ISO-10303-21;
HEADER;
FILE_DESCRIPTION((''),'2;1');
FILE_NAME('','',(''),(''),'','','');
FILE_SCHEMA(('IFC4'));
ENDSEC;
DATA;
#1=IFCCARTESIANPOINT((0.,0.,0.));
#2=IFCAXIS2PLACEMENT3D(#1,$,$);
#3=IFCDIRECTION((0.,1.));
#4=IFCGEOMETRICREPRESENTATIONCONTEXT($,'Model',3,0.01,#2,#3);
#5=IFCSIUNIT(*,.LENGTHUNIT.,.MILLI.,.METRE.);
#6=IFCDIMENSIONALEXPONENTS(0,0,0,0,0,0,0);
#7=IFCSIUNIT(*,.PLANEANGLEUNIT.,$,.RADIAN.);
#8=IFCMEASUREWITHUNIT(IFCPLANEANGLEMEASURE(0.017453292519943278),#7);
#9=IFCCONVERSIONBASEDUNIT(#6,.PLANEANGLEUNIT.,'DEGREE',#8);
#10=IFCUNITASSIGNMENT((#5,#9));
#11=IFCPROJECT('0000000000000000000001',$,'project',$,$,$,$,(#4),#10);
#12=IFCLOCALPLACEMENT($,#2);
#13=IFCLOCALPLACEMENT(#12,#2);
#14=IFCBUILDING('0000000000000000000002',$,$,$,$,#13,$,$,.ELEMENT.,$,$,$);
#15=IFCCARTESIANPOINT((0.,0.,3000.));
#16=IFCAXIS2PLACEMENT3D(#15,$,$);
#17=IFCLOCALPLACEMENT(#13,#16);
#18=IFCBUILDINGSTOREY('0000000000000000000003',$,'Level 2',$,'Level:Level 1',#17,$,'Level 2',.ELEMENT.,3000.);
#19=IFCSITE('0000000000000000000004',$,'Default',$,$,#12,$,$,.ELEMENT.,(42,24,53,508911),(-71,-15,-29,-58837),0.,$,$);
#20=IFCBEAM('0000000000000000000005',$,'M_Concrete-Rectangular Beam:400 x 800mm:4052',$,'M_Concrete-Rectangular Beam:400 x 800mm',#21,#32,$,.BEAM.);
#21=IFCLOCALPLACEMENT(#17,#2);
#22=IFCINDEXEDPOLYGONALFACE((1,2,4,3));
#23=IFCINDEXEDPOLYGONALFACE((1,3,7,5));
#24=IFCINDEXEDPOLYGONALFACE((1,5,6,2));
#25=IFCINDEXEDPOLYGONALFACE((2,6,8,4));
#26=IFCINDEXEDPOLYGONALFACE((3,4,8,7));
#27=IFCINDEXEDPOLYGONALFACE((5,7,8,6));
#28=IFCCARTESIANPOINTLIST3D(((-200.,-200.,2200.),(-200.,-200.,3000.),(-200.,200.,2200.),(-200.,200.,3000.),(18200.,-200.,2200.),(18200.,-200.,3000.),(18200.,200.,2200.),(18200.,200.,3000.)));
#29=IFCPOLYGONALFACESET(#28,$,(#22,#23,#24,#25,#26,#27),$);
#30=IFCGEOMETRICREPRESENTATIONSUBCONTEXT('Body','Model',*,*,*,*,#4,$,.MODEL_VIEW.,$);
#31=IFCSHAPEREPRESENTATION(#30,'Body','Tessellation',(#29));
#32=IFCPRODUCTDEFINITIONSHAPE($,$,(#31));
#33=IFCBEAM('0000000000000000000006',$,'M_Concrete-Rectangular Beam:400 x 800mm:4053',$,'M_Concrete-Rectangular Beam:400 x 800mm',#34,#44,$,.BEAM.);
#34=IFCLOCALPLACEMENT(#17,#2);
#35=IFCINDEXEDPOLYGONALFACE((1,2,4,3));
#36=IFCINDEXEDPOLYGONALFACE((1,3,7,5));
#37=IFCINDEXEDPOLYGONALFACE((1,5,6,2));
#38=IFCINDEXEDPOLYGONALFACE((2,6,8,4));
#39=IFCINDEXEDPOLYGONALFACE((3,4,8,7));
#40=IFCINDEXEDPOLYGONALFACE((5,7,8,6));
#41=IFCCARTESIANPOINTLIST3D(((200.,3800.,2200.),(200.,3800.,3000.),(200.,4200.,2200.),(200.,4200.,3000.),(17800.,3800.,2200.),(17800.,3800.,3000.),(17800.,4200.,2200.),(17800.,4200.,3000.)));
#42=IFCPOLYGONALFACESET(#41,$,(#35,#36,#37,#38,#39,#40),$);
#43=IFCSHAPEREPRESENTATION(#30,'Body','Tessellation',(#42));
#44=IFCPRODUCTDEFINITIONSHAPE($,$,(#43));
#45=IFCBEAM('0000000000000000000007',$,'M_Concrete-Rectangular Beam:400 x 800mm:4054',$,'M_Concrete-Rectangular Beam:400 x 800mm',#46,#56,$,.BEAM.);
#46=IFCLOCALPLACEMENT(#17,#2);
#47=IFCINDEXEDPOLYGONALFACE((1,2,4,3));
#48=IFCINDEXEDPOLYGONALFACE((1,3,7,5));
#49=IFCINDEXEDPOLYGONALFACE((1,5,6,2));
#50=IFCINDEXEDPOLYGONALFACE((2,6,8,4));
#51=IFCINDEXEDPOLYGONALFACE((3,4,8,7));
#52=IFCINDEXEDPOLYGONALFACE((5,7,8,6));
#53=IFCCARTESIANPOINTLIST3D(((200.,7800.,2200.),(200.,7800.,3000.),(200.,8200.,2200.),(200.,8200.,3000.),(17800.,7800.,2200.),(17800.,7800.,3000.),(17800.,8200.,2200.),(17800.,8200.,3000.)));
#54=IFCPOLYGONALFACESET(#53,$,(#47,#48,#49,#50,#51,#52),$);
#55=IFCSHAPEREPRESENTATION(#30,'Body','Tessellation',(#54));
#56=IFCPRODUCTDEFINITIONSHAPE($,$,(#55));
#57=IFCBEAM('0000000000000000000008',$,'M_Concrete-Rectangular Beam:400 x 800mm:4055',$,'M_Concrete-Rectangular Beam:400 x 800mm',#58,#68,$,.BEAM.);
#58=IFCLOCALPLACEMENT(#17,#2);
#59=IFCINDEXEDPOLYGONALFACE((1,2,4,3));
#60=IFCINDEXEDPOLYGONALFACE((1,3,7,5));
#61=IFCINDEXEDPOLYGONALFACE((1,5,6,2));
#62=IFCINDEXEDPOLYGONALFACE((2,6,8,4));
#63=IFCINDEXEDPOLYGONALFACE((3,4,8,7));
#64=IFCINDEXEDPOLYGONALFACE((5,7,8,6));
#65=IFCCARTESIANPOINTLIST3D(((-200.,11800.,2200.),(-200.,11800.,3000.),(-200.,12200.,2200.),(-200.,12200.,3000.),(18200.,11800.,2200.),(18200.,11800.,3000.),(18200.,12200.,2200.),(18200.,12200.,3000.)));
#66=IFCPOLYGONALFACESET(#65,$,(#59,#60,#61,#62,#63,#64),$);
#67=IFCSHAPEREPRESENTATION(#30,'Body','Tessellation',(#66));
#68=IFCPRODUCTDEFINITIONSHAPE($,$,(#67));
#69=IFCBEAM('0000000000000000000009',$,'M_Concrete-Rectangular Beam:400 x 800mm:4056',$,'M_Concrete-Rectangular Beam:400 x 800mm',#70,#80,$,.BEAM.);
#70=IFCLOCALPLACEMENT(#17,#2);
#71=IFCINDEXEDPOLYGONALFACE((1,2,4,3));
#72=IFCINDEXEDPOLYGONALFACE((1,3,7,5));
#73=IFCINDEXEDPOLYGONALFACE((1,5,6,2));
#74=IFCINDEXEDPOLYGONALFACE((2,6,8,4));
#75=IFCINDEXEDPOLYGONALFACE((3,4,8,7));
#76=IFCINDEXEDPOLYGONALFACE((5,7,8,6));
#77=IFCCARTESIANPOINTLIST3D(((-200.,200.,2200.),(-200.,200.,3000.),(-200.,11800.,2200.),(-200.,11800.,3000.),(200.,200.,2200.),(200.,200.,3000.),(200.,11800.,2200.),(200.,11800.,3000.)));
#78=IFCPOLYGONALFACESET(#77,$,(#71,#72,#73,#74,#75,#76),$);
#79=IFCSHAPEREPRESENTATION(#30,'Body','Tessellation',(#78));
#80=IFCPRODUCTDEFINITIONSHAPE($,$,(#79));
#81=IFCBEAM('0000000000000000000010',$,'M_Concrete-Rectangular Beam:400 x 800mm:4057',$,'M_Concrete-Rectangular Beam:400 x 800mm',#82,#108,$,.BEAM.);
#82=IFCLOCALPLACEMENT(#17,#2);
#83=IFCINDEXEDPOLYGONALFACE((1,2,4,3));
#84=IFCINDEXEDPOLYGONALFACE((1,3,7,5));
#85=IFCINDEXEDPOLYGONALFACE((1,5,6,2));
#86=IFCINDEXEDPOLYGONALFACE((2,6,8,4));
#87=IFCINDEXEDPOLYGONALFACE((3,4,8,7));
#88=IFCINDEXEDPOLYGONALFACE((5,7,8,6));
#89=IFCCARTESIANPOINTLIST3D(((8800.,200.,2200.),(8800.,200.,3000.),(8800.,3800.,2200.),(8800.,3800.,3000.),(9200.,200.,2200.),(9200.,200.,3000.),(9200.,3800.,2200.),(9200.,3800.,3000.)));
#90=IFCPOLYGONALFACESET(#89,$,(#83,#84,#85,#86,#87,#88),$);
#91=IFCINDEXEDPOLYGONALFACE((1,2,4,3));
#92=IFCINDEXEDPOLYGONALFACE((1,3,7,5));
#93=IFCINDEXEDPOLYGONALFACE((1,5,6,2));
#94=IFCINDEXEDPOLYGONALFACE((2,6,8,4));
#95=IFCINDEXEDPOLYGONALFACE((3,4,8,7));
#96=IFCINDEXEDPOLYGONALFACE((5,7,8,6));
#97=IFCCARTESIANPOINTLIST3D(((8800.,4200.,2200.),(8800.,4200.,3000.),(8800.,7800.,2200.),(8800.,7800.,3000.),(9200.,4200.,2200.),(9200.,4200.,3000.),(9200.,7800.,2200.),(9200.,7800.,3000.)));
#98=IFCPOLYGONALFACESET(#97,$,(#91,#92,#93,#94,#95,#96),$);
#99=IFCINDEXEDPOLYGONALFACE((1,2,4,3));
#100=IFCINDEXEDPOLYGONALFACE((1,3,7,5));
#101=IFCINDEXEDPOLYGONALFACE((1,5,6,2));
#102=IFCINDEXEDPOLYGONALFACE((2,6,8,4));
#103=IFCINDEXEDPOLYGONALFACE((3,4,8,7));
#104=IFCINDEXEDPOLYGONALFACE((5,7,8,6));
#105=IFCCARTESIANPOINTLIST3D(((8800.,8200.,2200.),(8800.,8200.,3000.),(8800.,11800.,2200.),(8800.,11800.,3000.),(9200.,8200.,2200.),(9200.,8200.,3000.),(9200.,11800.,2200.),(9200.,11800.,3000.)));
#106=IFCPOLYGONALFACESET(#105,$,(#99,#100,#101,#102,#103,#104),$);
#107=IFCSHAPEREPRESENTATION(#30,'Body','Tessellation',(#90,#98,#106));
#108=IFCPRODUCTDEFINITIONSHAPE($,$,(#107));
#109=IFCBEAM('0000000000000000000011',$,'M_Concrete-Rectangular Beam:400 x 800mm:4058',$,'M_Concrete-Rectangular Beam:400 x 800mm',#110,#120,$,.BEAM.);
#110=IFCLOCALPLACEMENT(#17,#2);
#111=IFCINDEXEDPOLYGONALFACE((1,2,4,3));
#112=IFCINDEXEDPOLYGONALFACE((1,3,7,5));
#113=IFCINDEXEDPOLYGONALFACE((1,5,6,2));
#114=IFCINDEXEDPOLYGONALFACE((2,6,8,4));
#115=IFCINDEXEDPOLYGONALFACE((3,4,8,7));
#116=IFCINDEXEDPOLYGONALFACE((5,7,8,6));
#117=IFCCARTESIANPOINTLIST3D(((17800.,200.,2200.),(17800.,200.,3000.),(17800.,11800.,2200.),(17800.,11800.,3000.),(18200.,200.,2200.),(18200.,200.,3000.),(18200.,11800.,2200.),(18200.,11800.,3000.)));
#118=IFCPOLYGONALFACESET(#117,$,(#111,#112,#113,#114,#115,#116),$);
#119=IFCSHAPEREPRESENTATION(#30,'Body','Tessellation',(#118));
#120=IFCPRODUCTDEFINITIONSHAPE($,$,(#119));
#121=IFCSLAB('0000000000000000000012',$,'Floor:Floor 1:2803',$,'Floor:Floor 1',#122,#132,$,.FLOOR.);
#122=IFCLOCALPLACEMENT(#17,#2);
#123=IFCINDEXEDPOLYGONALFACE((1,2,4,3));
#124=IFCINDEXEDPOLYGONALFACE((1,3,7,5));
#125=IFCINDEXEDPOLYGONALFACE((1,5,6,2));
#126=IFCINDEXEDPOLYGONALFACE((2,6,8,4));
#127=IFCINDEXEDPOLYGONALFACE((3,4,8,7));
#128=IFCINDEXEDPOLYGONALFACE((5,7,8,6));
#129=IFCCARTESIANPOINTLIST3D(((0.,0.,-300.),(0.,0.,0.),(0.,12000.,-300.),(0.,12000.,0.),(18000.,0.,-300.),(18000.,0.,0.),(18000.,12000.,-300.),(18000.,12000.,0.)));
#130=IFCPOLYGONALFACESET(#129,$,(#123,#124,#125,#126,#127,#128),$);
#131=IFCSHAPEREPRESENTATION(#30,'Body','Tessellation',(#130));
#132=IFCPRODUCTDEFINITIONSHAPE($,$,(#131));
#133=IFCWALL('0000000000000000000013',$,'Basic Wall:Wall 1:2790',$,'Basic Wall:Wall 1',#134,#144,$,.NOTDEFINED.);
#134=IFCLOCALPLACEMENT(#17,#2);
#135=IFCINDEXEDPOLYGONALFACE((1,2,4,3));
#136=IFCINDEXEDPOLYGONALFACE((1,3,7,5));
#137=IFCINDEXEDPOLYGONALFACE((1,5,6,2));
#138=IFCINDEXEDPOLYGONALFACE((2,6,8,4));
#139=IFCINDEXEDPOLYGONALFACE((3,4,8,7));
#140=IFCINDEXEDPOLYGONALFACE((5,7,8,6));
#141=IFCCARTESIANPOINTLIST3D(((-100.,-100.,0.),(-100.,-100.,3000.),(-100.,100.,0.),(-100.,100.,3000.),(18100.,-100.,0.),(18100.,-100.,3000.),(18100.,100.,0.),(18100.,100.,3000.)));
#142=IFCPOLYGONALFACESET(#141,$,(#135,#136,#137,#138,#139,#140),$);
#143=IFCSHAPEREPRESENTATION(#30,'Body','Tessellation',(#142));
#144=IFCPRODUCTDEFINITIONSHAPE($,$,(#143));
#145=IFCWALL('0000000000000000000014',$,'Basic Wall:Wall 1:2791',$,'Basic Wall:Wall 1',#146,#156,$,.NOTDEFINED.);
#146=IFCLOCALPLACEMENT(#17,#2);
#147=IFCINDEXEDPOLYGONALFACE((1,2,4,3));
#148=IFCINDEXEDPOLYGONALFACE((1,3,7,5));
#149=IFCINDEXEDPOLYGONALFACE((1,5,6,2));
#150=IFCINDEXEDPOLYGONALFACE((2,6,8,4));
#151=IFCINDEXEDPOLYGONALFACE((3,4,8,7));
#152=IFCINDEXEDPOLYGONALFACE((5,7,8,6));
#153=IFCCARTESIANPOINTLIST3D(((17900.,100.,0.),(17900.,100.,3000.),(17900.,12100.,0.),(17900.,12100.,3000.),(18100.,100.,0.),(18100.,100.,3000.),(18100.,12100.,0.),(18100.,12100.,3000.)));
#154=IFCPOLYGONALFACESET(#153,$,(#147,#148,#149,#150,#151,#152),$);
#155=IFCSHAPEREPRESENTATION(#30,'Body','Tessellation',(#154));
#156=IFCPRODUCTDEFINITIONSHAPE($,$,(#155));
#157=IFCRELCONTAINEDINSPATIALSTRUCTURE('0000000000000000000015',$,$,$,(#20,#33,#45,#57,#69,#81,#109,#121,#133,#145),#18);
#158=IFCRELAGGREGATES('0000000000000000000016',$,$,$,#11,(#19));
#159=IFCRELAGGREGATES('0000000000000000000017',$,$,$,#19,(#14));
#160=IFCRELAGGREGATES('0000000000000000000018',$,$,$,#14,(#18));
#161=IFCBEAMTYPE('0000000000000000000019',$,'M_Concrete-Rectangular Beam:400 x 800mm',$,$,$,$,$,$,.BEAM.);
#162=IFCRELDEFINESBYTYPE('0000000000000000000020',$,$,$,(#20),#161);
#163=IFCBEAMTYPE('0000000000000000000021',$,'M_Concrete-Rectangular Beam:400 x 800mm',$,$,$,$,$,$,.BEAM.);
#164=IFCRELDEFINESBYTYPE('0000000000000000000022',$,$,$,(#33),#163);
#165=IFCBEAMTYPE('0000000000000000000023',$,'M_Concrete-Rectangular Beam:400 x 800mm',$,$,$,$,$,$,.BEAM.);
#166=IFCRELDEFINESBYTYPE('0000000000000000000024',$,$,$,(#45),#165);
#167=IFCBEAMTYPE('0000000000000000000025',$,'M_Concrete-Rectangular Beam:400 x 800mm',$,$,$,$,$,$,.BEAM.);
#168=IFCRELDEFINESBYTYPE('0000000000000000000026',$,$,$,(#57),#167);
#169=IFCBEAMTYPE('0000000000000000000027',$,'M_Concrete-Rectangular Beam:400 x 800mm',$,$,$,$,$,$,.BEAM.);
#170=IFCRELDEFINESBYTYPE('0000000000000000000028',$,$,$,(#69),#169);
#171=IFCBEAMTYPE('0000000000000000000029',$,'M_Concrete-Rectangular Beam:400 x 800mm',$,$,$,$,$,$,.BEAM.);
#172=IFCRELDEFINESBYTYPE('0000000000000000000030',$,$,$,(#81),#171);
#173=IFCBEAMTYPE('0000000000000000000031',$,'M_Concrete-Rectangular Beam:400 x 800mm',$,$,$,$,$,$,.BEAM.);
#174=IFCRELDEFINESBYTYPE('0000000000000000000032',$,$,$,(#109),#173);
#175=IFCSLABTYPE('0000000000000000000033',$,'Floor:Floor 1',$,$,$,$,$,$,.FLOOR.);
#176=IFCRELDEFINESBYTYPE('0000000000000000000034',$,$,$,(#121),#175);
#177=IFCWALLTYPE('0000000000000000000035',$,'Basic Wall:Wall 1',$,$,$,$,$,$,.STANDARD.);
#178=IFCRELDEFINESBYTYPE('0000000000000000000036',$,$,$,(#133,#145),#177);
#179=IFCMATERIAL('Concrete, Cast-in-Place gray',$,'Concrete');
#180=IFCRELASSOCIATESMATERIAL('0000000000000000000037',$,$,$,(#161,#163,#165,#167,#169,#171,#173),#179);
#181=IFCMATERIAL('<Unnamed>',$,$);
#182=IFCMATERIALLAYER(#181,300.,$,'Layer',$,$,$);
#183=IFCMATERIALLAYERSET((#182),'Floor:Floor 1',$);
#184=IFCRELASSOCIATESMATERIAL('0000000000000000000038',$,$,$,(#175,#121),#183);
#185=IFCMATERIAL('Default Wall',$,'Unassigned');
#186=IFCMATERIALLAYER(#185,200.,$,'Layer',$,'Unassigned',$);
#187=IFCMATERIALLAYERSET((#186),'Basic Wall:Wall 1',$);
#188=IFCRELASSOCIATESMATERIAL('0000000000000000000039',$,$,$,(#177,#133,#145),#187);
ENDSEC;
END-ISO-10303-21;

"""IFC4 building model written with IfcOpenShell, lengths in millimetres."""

from ifc_helpers import new_model, entity, si_unit, converted_unit, direction, frame, frame_2d, origin, origin_2d_with_axis, place, context, subcontext, project, spatial, rectangle, extrude, source, transform, mapped, material, layer, layer_set, layer_usage, material_profile, profile_set, type_object, type_shapes, element, save


model = new_model("IFC4")

# Units and contexts
model_context = context("Model", 3, precision=0.01, world=origin(), true_north=direction((0.0, 1.0)))
body_context = subcontext(model_context, "Body", "Model", "MODEL_VIEW")
ifc_project = project(units=[si_unit("LENGTHUNIT", "METRE", prefix="MILLI"), converted_unit("PLANEANGLEUNIT", "DEGREE", entity("IfcPlaneAngleMeasure", 0.017453292519943278), si_unit("PLANEANGLEUNIT", "RADIAN"), dimensions=[0, 0, 0, 0, 0, 0, 0])], contexts=[model_context])

# Site, building, storey
site_placement = place(None, origin())
site = spatial("IfcSite", under=ifc_project, at=site_placement, Name="Default", CompositionType="ELEMENT", RefLatitude=(42, 24, 53, 508911), RefLongitude=(-71, -15, -29, -58837), RefElevation=0.0)
building_placement = place(site_placement, origin())
building = spatial("IfcBuilding", under=site, at=building_placement, CompositionType="ELEMENT")
storey_placement = place(building_placement, frame((0.0, 0.0, 3000.0)))
storey = spatial("IfcBuildingStorey", under=building, at=storey_placement, Name="Level 2", ObjectType="Level:Level 1", LongName="Level 2", CompositionType="ELEMENT", Elevation=3000.0)

# Beams
ifc_material_1 = material(Name="Concrete, Cast-in-Place gray", Category="Concrete")
ifc_material_profile = material_profile(ifc_material_1, rectangle(XDim=800.0, YDim=400.0, at=origin_2d_with_axis()), Name="400 x 800mm")
ifc_profile_set = profile_set([ifc_material_profile], Name="400 x 800mm")
beam_type_1 = type_object("IfcBeamType", Name="M_Concrete-Rectangular Beam:400 x 800mm", PredefinedType="BEAM", material=ifc_profile_set)
shared_shape_1 = source(origin(), body_context, "Body", "SweptSolid", [
    extrude(rectangle(XDim=800.0, YDim=400.0, at=origin_2d_with_axis()), frame((-200.0, 0.0, 5600.0), z_axis=(1.0, 0.0, 0.0), x_axis=(0.0, 0.0, -1.0)), (0.0, 0.0, 1.0), 18400.0),
])
type_shapes(beam_type_1, [shared_shape_1])
beam_1_placement = place(storey_placement, frame((0.0, 0.0, -3000.0)))
element("IfcBeam", 1, at=beam_1_placement, inside=storey, type_object=beam_type_1, Name="M_Concrete-Rectangular Beam:400 x 800mm:4052", ObjectType="M_Concrete-Rectangular Beam:400 x 800mm", PredefinedType="BEAM", context=body_context, shape_type="MappedRepresentation", body=[
    mapped(shared_shape_1, transform((0.0, 0.0, 0.0), scale=1.0)),
])
beam_type_2 = type_object("IfcBeamType", Name="M_Concrete-Rectangular Beam:400 x 800mm", PredefinedType="BEAM", material=ifc_profile_set)
shared_shape_2 = source(origin(), body_context, "Body", "SweptSolid", [
    extrude(rectangle(XDim=800.0, YDim=400.0, at=origin_2d_with_axis()), frame((200.0, 4000.0, 5600.0), z_axis=(1.0, 0.0, 0.0), x_axis=(0.0, 0.0, -1.0)), (0.0, 0.0, 1.0), 17600.0),
])
type_shapes(beam_type_2, [shared_shape_2])
beam_2_placement = place(storey_placement, frame((0.0, 0.0, -3000.0)))
element("IfcBeam", 2, at=beam_2_placement, inside=storey, type_object=beam_type_2, Name="M_Concrete-Rectangular Beam:400 x 800mm:4053", ObjectType="M_Concrete-Rectangular Beam:400 x 800mm", PredefinedType="BEAM", context=body_context, shape_type="MappedRepresentation", body=[
    mapped(shared_shape_2, transform((0.0, 0.0, 0.0), scale=1.0)),
])
beam_type_3 = type_object("IfcBeamType", Name="M_Concrete-Rectangular Beam:400 x 800mm", PredefinedType="BEAM", material=ifc_profile_set)
shared_shape_3 = source(origin(), body_context, "Body", "SweptSolid", [
    extrude(rectangle(XDim=800.0, YDim=400.0, at=frame_2d((0.0, 0.0), x_axis=(1.0, 0.0))), frame((200.0, 8000.0, 5600.0), z_axis=(1.0, 0.0, 0.0), x_axis=(0.0, 0.0, -1.0)), (0.0, 0.0, 1.0), 17600.0),
])
type_shapes(beam_type_3, [shared_shape_3])
beam_3_placement = place(storey_placement, frame((0.0, 0.0, -3000.0)))
element("IfcBeam", 3, at=beam_3_placement, inside=storey, type_object=beam_type_3, Name="M_Concrete-Rectangular Beam:400 x 800mm:4054", ObjectType="M_Concrete-Rectangular Beam:400 x 800mm", PredefinedType="BEAM", context=body_context, shape_type="MappedRepresentation", body=[
    mapped(shared_shape_3, transform((0.0, 0.0, 0.0), scale=1.0)),
])
beam_type_4 = type_object("IfcBeamType", Name="M_Concrete-Rectangular Beam:400 x 800mm", PredefinedType="BEAM", material=ifc_profile_set)
shared_shape_4 = source(origin(), body_context, "Body", "SweptSolid", [
    extrude(rectangle(XDim=800.0, YDim=400.0, at=frame_2d((0.0, 0.0), x_axis=(1.0, 0.0))), frame((-200.0, 12000.0, 5600.0), z_axis=(1.0, 0.0, 0.0), x_axis=(0.0, 0.0, -1.0)), (0.0, 0.0, 1.0), 18400.0),
])
type_shapes(beam_type_4, [shared_shape_4])
beam_4_placement = place(storey_placement, frame((0.0, 0.0, -3000.0)))
element("IfcBeam", 4, at=beam_4_placement, inside=storey, type_object=beam_type_4, Name="M_Concrete-Rectangular Beam:400 x 800mm:4055", ObjectType="M_Concrete-Rectangular Beam:400 x 800mm", PredefinedType="BEAM", context=body_context, shape_type="MappedRepresentation", body=[
    mapped(shared_shape_4, transform((0.0, 0.0, 0.0), scale=1.0)),
])
beam_type_5 = type_object("IfcBeamType", Name="M_Concrete-Rectangular Beam:400 x 800mm", PredefinedType="BEAM", material=ifc_profile_set)
shared_shape_5 = source(origin(), body_context, "Body", "SweptSolid", [
    extrude(rectangle(XDim=800.0, YDim=400.0, at=frame_2d((0.0, 0.0), x_axis=(0.0, 1.0))), frame((0.0, 200.0, 5600.0), z_axis=(0.0, 1.0, 0.0), x_axis=(-1.0, 0.0, 0.0)), (0.0, 0.0, 1.0), 11600.0),
])
type_shapes(beam_type_5, [shared_shape_5])
beam_5_placement = place(storey_placement, frame((0.0, 0.0, -3000.0)))
element("IfcBeam", 5, at=beam_5_placement, inside=storey, type_object=beam_type_5, Name="M_Concrete-Rectangular Beam:400 x 800mm:4056", ObjectType="M_Concrete-Rectangular Beam:400 x 800mm", PredefinedType="BEAM", context=body_context, shape_type="MappedRepresentation", body=[
    mapped(shared_shape_5, transform((0.0, 0.0, 0.0), scale=1.0)),
])
beam_type_6 = type_object("IfcBeamType", Name="M_Concrete-Rectangular Beam:400 x 800mm", PredefinedType="BEAM", material=ifc_profile_set)
shared_shape_6 = source(origin(), body_context, "Body", "SweptSolid", [
    extrude(rectangle(XDim=800.0, YDim=400.0, at=frame_2d((0.0, 0.0), x_axis=(0.0, 1.0))), frame((9000.0, 200.0, 5600.0), z_axis=(0.0, 1.0, 0.0), x_axis=(-1.0, 0.0, 0.0)), (0.0, 0.0, 1.0), 3600.0),
    extrude(rectangle(XDim=800.0, YDim=400.0, at=frame_2d((0.0, 0.0), x_axis=(0.0, 1.0))), frame((9000.0, 4200.0, 5600.0), z_axis=(0.0, 1.0, 0.0), x_axis=(-1.0, 0.0, 0.0)), (0.0, 0.0, 1.0), 3600.0),
    extrude(rectangle(XDim=800.0, YDim=400.0, at=frame_2d((0.0, 0.0), x_axis=(0.0, 1.0))), frame((9000.0, 8200.0, 5600.0), z_axis=(0.0, 1.0, 0.0), x_axis=(-1.0, 0.0, 0.0)), (0.0, 0.0, 1.0), 3600.0),
])
type_shapes(beam_type_6, [shared_shape_6])
beam_6_placement = place(storey_placement, frame((0.0, 0.0, -3000.0)))
element("IfcBeam", 6, at=beam_6_placement, inside=storey, type_object=beam_type_6, Name="M_Concrete-Rectangular Beam:400 x 800mm:4057", ObjectType="M_Concrete-Rectangular Beam:400 x 800mm", PredefinedType="BEAM", context=body_context, shape_type="MappedRepresentation", body=[
    mapped(shared_shape_6, transform((0.0, 0.0, 0.0), scale=1.0)),
])
beam_type_7 = type_object("IfcBeamType", Name="M_Concrete-Rectangular Beam:400 x 800mm", PredefinedType="BEAM", material=ifc_profile_set)
shared_shape_7 = source(origin(), body_context, "Body", "SweptSolid", [
    extrude(rectangle(XDim=800.0, YDim=400.0, at=frame_2d((0.0, 0.0), x_axis=(0.0, 1.0))), frame((18000.0, 200.0, 5600.0), z_axis=(0.0, 1.0, 0.0), x_axis=(-1.0, 0.0, 0.0)), (0.0, 0.0, 1.0), 11600.0),
])
type_shapes(beam_type_7, [shared_shape_7])
beam_7_placement = place(storey_placement, frame((0.0, 0.0, -3000.0)))
element("IfcBeam", 7, at=beam_7_placement, inside=storey, type_object=beam_type_7, Name="M_Concrete-Rectangular Beam:400 x 800mm:4058", ObjectType="M_Concrete-Rectangular Beam:400 x 800mm", PredefinedType="BEAM", context=body_context, shape_type="MappedRepresentation", body=[
    mapped(shared_shape_7, transform((0.0, 0.0, 0.0), scale=1.0)),
])

# Slab
ifc_material_2 = material(Name="<Unnamed>")
ifc_layer_1 = layer(ifc_material_2, 300.0, Name="Layer")
ifc_layer_set_1 = layer_set([ifc_layer_1], Name="Floor:Floor 1")
ifc_layer_usage_1 = layer_usage(ifc_layer_set_1, "AXIS3", "POSITIVE", 0.0)
slab_type = type_object("IfcSlabType", Name="Floor:Floor 1", PredefinedType="FLOOR", material=ifc_layer_set_1)
slab_placement = place(storey_placement, origin())
element("IfcSlab", 8, at=slab_placement, inside=storey, type_object=slab_type, material=ifc_layer_usage_1, Name="Floor:Floor 1:2803", ObjectType="Floor:Floor 1", PredefinedType="FLOOR", context=body_context, shape_type="SweptSolid", body=[
    extrude(rectangle(XDim=12000.0, YDim=18000.0, at=origin_2d_with_axis()), frame((9000.0, 6000.0, 0.0), z_axis=(0.0, 0.0, -1.0), x_axis=(0.0, 1.0, 0.0)), (0.0, 0.0, 1.0), 300.0),
])

# Walls
ifc_material_3 = material(Name="Default Wall", Category="Unassigned")
ifc_layer_2 = layer(ifc_material_3, 200.0, Name="Layer", Category="Unassigned")
ifc_layer_set_2 = layer_set([ifc_layer_2], Name="Basic Wall:Wall 1")
ifc_layer_usage_2 = layer_usage(ifc_layer_set_2, "AXIS2", "NEGATIVE", 100.0)
wall_type = type_object("IfcWallType", Name="Basic Wall:Wall 1", PredefinedType="STANDARD", material=ifc_layer_set_2)
wall_1_placement = place(storey_placement, frame((-100.0, 0.0, 0.0)))
element("IfcWall", 9, at=wall_1_placement, inside=storey, type_object=wall_type, material=ifc_layer_usage_2, Name="Basic Wall:Wall 1:2790", ObjectType="Basic Wall:Wall 1", PredefinedType="NOTDEFINED", context=body_context, shape_type="SweptSolid", body=[
    extrude(rectangle(XDim=18200.0, YDim=200.0, at=frame_2d((9100.0, 0.0), x_axis=(-1.0, 0.0))), origin(), (0.0, 0.0, 1.0), 3000.0),
])
ifc_layer_usage_3 = layer_usage(ifc_layer_set_2, "AXIS2", "NEGATIVE", 100.0)
wall_2_placement = place(storey_placement, frame((18000.0, 100.0, 0.0), z_axis=(0.0, 0.0, 1.0), x_axis=(0.0, 1.0, 0.0)))
element("IfcWall", 10, at=wall_2_placement, inside=storey, type_object=wall_type, material=ifc_layer_usage_3, Name="Basic Wall:Wall 1:2791", ObjectType="Basic Wall:Wall 1", PredefinedType="NOTDEFINED", context=body_context, shape_type="SweptSolid", body=[
    extrude(rectangle(XDim=12000.0, YDim=200.0, at=frame_2d((6000.0, 0.0), x_axis=(-1.0, 0.0))), origin(), (0.0, 0.0, 1.0), 3000.0),
])

save(model, "model.ifc")
